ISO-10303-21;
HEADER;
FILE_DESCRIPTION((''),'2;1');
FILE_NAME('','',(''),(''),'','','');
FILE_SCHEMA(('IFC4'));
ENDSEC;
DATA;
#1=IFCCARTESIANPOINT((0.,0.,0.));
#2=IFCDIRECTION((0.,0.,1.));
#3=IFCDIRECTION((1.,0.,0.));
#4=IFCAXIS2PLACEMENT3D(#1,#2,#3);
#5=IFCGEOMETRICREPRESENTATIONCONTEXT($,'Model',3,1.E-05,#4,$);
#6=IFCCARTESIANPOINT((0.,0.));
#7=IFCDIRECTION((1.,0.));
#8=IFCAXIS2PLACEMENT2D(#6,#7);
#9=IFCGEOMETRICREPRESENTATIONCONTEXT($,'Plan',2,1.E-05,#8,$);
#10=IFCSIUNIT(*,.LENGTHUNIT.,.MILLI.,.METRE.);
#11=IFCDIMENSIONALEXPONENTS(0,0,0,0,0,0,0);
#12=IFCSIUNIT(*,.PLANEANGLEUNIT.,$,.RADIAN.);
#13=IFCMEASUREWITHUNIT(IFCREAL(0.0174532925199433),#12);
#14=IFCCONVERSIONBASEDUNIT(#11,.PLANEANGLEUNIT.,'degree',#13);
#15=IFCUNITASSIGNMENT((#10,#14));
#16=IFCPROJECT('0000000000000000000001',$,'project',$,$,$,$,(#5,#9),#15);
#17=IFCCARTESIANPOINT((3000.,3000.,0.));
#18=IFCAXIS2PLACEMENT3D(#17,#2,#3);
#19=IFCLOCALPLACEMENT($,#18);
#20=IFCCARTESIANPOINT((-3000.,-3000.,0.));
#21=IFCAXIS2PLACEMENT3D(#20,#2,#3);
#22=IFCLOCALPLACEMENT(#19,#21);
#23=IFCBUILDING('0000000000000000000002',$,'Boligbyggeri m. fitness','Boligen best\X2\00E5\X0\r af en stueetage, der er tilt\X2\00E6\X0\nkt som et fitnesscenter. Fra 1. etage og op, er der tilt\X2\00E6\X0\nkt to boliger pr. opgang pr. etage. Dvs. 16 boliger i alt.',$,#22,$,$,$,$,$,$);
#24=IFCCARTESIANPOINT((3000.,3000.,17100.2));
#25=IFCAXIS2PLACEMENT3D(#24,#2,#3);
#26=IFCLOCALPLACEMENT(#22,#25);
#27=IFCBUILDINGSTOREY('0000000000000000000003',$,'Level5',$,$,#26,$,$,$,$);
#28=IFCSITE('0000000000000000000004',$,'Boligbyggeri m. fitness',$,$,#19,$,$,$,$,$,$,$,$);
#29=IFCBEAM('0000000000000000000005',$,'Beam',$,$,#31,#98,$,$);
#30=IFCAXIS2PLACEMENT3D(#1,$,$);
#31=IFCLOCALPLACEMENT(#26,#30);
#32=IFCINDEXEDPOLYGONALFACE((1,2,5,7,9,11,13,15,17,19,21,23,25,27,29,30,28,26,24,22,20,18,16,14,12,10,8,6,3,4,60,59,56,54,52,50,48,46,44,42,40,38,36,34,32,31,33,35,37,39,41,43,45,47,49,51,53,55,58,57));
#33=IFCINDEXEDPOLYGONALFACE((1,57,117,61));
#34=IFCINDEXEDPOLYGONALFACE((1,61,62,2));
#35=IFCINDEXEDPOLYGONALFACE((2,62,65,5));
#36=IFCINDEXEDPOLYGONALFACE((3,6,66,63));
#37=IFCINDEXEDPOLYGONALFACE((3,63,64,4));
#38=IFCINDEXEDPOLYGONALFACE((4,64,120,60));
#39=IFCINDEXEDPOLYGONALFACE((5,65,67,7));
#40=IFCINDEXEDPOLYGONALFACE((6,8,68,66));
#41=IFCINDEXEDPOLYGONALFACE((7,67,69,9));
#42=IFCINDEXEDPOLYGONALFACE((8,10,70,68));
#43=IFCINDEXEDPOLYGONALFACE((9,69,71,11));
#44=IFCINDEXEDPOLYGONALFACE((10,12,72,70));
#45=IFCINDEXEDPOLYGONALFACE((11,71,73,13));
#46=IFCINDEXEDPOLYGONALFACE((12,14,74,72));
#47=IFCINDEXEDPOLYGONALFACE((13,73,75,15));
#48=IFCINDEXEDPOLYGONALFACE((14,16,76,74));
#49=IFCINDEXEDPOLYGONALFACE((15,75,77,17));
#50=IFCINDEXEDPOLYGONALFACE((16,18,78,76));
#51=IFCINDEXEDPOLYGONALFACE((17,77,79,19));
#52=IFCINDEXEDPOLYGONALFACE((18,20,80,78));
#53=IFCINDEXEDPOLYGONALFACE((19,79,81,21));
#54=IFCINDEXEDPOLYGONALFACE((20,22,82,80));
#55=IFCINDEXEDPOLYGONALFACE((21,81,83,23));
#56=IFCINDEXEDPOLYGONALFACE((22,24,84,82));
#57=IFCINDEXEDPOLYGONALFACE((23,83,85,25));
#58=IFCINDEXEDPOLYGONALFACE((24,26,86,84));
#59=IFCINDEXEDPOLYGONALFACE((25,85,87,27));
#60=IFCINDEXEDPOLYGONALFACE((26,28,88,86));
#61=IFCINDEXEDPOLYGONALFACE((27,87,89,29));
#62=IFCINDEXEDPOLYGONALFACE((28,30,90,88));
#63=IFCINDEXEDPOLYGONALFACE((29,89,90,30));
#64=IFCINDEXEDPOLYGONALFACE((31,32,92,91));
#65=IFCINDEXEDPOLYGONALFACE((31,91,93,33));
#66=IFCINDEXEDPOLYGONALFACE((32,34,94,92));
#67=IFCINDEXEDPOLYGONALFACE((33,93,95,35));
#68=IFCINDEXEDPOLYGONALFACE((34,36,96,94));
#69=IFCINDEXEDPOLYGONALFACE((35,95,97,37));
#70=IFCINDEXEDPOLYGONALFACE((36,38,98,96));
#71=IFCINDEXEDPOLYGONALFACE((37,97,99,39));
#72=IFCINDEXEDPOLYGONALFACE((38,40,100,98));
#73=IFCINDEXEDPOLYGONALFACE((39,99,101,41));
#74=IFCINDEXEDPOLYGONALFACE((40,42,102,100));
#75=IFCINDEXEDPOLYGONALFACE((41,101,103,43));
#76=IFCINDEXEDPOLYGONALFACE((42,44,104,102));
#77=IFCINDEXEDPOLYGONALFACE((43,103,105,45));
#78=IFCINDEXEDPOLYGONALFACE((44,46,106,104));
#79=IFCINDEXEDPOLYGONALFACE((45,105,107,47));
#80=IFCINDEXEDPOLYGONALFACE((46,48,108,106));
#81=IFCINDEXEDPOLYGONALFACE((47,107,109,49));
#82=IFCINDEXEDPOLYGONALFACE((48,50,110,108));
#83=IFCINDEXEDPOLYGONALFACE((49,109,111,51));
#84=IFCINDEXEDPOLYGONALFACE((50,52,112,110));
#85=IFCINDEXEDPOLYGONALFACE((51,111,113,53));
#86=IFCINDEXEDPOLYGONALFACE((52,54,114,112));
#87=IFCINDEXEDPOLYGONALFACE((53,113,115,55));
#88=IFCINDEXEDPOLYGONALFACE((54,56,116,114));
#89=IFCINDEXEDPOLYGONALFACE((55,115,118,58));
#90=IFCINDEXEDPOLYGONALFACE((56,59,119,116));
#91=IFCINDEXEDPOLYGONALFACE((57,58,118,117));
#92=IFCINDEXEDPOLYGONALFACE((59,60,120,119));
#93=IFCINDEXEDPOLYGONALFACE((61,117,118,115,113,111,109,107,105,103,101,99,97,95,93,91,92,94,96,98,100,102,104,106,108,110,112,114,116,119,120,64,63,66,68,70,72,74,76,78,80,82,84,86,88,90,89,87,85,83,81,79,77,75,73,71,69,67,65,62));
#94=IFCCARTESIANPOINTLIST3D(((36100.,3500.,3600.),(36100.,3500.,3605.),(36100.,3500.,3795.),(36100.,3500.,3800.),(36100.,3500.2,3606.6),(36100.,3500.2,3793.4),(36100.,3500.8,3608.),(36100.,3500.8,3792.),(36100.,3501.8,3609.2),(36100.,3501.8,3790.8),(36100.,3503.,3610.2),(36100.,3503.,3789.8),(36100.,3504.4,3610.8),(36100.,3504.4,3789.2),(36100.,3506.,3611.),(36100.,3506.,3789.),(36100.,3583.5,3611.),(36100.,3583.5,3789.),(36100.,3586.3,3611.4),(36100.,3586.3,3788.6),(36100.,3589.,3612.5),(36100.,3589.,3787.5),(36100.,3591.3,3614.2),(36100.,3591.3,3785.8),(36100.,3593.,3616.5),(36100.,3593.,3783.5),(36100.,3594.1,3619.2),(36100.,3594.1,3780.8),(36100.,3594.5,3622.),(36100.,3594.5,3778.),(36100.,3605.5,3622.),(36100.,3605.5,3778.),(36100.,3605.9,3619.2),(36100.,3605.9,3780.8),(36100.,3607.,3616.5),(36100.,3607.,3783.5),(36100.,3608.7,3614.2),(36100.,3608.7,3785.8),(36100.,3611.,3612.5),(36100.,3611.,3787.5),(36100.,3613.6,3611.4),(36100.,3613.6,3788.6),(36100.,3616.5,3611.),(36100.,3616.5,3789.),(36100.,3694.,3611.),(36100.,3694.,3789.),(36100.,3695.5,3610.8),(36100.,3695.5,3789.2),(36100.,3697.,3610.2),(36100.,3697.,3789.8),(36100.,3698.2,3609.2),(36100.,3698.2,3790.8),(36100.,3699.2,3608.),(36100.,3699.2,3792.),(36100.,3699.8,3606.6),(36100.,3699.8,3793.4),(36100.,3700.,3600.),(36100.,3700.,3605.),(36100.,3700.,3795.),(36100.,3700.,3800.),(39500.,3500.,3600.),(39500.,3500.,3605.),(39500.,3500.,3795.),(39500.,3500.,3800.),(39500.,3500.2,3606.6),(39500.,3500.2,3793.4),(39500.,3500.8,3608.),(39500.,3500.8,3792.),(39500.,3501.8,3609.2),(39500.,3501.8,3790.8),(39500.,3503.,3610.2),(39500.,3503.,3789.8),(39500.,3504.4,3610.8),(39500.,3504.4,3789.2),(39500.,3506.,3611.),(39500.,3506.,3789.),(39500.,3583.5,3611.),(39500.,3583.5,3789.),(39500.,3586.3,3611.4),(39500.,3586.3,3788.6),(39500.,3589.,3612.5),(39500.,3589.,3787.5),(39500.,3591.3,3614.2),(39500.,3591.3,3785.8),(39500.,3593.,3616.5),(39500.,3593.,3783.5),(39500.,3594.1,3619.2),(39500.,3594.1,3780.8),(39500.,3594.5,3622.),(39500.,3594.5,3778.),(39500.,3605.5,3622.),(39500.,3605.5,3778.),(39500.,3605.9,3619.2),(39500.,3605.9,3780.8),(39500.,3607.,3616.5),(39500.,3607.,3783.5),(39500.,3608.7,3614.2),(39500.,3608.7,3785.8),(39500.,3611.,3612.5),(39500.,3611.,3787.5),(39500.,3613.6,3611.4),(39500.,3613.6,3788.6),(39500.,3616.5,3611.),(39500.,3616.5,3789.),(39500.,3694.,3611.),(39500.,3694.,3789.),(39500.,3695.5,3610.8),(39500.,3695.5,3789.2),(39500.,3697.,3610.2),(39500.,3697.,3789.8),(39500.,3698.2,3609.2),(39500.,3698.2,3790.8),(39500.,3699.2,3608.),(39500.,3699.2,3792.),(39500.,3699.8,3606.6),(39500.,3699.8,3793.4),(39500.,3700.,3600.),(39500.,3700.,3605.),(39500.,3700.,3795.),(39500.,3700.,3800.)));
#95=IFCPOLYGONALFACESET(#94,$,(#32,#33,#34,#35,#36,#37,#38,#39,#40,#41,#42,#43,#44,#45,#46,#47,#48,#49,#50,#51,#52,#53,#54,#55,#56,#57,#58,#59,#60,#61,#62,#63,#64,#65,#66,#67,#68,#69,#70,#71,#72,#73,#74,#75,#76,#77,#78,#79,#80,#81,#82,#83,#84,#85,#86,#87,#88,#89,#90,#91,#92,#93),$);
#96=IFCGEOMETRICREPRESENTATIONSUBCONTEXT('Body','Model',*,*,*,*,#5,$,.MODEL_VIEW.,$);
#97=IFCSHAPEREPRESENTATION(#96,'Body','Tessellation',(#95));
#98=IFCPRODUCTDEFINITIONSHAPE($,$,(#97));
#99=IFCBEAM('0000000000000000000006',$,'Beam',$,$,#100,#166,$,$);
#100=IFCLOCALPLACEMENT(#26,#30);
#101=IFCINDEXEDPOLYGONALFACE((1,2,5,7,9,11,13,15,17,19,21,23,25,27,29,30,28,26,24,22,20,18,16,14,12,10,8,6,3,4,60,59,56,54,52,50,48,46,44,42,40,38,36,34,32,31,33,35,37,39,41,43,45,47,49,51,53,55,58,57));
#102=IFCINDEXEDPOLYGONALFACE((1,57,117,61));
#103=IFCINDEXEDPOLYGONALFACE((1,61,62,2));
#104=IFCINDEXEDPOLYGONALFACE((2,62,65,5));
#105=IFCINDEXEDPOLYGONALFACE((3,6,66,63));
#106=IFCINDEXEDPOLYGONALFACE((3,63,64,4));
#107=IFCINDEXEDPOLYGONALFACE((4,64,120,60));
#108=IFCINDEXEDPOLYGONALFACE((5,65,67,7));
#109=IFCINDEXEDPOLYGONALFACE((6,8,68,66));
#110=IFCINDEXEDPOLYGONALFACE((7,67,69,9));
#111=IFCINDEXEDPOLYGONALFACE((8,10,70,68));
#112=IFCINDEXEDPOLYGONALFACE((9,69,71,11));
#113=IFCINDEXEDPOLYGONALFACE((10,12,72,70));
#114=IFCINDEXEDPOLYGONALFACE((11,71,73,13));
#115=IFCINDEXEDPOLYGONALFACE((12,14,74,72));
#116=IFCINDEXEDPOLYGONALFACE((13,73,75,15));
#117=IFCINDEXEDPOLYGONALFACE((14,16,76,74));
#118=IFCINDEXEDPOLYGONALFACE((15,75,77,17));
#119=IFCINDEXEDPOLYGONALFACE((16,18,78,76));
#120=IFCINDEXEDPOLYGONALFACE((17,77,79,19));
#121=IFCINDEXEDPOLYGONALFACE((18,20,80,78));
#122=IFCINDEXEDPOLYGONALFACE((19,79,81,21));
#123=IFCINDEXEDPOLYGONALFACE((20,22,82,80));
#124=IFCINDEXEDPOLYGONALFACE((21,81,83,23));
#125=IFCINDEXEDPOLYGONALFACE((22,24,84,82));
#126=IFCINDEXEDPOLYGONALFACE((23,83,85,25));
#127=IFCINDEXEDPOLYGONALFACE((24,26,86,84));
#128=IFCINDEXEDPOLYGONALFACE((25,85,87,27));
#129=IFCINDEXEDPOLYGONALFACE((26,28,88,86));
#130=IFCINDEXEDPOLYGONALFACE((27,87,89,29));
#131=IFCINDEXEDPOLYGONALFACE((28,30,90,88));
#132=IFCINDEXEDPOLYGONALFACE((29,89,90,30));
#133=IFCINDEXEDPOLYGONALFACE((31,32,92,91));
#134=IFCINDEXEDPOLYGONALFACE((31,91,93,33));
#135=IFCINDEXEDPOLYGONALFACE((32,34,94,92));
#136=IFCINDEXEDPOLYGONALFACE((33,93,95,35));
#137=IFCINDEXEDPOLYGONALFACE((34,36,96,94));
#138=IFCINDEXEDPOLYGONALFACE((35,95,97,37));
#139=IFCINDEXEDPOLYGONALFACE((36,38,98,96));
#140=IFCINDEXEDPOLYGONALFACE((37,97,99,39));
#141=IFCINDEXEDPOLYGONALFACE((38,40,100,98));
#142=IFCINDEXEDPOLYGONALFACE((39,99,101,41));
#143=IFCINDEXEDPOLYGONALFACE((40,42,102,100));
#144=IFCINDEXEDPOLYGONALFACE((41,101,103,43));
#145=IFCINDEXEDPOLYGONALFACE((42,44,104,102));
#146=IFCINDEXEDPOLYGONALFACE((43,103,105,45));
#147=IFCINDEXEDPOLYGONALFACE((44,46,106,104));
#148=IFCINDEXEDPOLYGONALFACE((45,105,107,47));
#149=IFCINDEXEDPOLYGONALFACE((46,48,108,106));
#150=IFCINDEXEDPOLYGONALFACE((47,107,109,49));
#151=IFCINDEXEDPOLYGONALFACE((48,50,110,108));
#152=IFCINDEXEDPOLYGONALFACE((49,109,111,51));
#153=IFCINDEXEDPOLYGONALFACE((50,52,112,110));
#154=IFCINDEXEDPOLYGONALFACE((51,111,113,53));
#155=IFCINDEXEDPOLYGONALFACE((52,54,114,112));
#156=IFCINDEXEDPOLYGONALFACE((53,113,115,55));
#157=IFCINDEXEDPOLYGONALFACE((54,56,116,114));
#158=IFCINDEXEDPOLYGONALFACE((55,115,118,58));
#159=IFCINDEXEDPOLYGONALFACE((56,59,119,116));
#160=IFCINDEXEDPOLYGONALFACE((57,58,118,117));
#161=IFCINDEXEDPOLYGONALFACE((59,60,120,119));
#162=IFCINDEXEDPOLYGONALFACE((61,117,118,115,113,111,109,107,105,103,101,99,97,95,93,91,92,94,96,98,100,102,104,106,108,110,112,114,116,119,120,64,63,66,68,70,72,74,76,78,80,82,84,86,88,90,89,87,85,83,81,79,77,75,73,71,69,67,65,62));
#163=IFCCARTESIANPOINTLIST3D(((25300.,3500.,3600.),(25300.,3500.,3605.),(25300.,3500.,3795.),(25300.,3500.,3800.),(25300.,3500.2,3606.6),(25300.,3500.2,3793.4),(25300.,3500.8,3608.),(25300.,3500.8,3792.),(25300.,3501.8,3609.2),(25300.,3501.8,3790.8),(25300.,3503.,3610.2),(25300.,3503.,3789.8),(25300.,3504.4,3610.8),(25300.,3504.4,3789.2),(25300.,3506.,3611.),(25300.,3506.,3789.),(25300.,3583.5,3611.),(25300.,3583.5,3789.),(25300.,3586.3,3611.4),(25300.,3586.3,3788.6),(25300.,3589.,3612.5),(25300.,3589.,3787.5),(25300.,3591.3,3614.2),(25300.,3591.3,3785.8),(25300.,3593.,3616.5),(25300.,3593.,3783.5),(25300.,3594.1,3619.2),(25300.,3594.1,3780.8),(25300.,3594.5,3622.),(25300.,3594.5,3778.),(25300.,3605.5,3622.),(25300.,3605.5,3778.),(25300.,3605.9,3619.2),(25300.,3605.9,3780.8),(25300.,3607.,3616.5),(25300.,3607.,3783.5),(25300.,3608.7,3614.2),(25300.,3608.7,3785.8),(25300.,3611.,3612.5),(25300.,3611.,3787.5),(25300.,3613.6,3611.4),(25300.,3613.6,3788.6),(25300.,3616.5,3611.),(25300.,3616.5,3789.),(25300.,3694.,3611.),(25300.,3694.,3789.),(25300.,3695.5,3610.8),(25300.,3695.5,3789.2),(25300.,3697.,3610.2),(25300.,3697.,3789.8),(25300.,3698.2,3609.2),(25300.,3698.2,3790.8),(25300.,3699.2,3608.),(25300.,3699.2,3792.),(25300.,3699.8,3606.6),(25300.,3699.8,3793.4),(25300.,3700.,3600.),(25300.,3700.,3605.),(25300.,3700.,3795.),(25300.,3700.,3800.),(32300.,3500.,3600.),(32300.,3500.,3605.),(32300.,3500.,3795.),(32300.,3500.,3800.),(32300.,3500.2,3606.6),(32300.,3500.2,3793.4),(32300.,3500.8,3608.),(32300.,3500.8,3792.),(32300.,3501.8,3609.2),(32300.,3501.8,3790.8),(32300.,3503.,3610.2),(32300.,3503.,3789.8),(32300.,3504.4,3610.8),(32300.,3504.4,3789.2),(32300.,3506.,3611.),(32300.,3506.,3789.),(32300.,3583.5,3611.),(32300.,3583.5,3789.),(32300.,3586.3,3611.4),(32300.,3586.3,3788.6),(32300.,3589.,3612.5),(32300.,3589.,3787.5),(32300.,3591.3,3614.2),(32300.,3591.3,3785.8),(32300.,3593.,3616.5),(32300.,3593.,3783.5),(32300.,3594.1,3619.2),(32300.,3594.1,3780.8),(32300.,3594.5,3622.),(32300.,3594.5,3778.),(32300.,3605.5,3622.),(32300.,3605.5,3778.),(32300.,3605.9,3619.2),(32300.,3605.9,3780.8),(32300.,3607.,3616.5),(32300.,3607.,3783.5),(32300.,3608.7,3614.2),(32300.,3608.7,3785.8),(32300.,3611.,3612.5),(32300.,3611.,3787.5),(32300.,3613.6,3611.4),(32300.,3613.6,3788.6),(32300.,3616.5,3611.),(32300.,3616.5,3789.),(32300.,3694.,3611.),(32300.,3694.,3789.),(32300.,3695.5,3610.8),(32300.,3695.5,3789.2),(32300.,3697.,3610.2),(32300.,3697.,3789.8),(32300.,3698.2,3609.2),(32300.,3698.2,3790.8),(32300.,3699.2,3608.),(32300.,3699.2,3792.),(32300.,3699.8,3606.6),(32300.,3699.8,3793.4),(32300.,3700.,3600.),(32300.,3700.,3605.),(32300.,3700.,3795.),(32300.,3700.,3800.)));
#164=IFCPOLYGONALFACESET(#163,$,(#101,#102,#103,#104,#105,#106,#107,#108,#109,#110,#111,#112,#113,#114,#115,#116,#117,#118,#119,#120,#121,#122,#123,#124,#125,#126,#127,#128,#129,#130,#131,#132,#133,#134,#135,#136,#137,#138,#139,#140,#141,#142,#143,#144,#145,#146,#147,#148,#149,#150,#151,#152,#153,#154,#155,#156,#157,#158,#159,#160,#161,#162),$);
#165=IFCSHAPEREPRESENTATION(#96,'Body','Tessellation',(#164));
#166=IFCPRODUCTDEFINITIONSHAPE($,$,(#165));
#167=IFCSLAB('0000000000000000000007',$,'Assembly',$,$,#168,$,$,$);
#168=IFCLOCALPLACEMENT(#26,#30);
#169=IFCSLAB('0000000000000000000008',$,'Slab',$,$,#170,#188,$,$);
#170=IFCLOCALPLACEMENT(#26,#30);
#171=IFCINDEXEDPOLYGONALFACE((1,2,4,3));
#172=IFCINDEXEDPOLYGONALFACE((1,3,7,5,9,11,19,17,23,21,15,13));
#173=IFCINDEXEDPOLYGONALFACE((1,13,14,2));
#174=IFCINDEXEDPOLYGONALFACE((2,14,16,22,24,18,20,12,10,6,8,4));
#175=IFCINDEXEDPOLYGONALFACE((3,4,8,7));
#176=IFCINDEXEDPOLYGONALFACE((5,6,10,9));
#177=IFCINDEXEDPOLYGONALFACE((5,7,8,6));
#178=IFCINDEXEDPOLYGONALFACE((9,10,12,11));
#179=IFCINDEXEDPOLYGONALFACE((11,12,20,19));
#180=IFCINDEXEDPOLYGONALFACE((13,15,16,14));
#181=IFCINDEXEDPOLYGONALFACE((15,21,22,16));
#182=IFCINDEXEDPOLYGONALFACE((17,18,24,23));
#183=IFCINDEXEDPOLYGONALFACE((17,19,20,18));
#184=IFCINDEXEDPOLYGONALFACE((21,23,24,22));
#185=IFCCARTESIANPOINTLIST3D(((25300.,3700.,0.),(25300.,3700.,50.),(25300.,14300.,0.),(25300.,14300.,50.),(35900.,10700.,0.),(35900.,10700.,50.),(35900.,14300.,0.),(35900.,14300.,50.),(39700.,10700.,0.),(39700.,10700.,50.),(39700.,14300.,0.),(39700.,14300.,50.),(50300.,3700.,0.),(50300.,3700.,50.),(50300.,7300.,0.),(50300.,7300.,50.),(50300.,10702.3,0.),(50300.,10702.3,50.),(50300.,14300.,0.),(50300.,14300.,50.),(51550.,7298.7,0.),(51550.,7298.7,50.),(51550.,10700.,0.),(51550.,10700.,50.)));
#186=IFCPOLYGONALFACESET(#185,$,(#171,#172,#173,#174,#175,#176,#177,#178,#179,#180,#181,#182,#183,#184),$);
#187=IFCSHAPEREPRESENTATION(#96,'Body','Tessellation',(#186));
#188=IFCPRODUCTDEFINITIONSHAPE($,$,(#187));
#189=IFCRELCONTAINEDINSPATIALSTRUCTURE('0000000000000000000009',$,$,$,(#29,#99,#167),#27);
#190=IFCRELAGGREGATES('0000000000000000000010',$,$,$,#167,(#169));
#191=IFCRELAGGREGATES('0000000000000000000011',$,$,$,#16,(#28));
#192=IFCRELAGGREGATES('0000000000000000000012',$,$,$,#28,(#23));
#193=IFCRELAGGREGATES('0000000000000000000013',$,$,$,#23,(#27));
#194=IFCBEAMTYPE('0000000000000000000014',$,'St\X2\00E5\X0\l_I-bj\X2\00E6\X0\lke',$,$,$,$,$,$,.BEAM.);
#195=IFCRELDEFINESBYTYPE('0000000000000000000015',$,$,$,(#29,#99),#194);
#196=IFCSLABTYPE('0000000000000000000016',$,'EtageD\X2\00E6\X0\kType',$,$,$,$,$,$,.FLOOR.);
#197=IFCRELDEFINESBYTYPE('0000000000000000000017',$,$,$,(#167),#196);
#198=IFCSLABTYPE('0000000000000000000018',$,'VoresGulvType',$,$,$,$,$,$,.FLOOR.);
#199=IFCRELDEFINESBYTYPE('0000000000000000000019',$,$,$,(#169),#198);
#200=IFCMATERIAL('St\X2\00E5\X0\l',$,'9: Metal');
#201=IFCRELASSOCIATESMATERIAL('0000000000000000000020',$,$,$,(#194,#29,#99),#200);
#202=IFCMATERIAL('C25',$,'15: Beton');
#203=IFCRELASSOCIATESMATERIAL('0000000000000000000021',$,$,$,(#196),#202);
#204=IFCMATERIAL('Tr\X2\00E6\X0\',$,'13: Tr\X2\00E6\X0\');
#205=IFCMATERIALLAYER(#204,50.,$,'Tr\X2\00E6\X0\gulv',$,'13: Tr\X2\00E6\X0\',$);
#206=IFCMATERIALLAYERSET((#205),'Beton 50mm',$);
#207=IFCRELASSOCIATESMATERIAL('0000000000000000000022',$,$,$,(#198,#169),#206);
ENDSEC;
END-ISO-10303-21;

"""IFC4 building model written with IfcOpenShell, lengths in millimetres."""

from ifc_helpers import new_model, entity, si_unit, converted_unit, frame, origin_with_axes, origin_2d_with_axis, place, context, subcontext, project, spatial, line, indexed_curve, i_section, outline, extrude, material, layer, layer_set, layer_usage, material_profile, profile_set, profile_usage, type_object, element, aggregate, save


model = new_model("IFC4")

# Units and contexts
model_context = context("Model", 3, precision=1e-05, world=origin_with_axes())
plan_context = context("Plan", 2, precision=1e-05, world=origin_2d_with_axis())
body_context = subcontext(model_context, "Body", "Model", "MODEL_VIEW")
ifc_project = project(units=[si_unit("LENGTHUNIT", "METRE", prefix="MILLI"), converted_unit("PLANEANGLEUNIT", "degree", entity("IfcReal", 0.0174532925199433), si_unit("PLANEANGLEUNIT", "RADIAN"), dimensions=[0, 0, 0, 0, 0, 0, 0])], contexts=[model_context, plan_context])

# Site, building, storey
site_placement = place(None, frame((3000.0, 3000.0, 0.0), z_axis=(0.0, 0.0, 1.0), x_axis=(1.0, 0.0, 0.0)))
site = spatial("IfcSite", under=ifc_project, at=site_placement, Name="Boligbyggeri m. fitness")
building_placement = place(site_placement, frame((-3000.0, -3000.0, 0.0), z_axis=(0.0, 0.0, 1.0), x_axis=(1.0, 0.0, 0.0)))
building = spatial("IfcBuilding", under=site, at=building_placement, Name="Boligbyggeri m. fitness", Description="Boligen består af en stueetage, der er tiltænkt som et fitnesscenter. Fra 1. etage og op, er der tiltænkt to boliger pr. opgang pr. etage. Dvs. 16 boliger i alt.")
storey_placement = place(building_placement, frame((3000.0, 3000.0, 17100.2), z_axis=(0.0, 0.0, 1.0), x_axis=(1.0, 0.0, 0.0)))
storey = spatial("IfcBuildingStorey", under=building, at=storey_placement, Name="Level5")

# Shared definitions
ifc_material_1 = material(Name="C25", Category="15: Beton")

# Beams
ifc_material_2 = material(Name="Stål", Category="9: Metal")
ifc_material_profile_1 = material_profile(ifc_material_2, i_section(OverallWidth=200.0, OverallDepth=200.0, WebThickness=11.0, FlangeThickness=11.0, FilletRadius=11.0, FlangeEdgeRadius=6.0), Name="Stål", Category="9: Metal")
ifc_profile_set_1 = profile_set([ifc_material_profile_1], Name="NY_I-Profil")
beam_type = type_object("IfcBeamType", Name="Stål_I-bjælke", PredefinedType="BEAM", material=ifc_profile_set_1)
ifc_profile_usage_1 = profile_usage(ifc_profile_set_1, cardinal=7)
beam_1_placement = place(storey_placement, frame((36100.0, 3700.0, 3800.0), z_axis=(1.0, 0.0, 0.0), x_axis=(0.0, 1.0, 0.0)))
element("IfcBeam", 1, at=beam_1_placement, inside=storey, type_object=beam_type, material=ifc_profile_usage_1, Name="Beam", context=body_context, shape_type="SweptSolid", body=[
    extrude(i_section(OverallWidth=200.0, OverallDepth=200.0, WebThickness=11.0, FlangeThickness=11.0, FilletRadius=11.0, FlangeEdgeRadius=6.0), frame((-100.0, -100.0, 0.0), z_axis=(0.0, 0.0, 1.0), x_axis=(1.0, 0.0, 0.0)), (0.0, 0.0, 1.0), 3400.0),
])
ifc_profile_usage_2 = profile_usage(ifc_profile_set_1, cardinal=7)
beam_2_placement = place(storey_placement, frame((25300.0, 3700.0, 3800.0), z_axis=(1.0, 0.0, 0.0), x_axis=(0.0, 1.0, 0.0)))
element("IfcBeam", 2, at=beam_2_placement, inside=storey, type_object=beam_type, material=ifc_profile_usage_2, Name="Beam", context=body_context, shape_type="SweptSolid", body=[
    extrude(i_section(OverallWidth=200.0, OverallDepth=200.0, WebThickness=11.0, FlangeThickness=11.0, FilletRadius=11.0, FlangeEdgeRadius=6.0), frame((-100.0, -100.0, 0.0), z_axis=(0.0, 0.0, 1.0), x_axis=(1.0, 0.0, 0.0)), (0.0, 0.0, 1.0), 7000.0),
])

# Slabs
slab_type_1 = type_object("IfcSlabType", Name="EtageDækType", PredefinedType="FLOOR", material=ifc_material_1)
slab_1_placement = place(storey_placement, frame((25300.0, 3700.0, -17099.9), z_axis=(0.0, 0.0, 1.0), x_axis=(1.0, 0.0, 0.0)))
slab_1 = element("IfcSlab", 3, at=slab_1_placement, inside=storey, type_object=slab_type_1, Name="Assembly")
ifc_material_3 = material(Name="Træ", Category="13: Træ")
ifc_layer_1 = layer(ifc_material_3, 50.0, Name="Trægulv", Category="13: Træ")
ifc_layer_set_1 = layer_set([ifc_layer_1], Name="Beton 50mm")
ifc_layer_usage_1 = layer_usage(ifc_layer_set_1, "AXIS3", "POSITIVE", 0.0)
slab_type_2 = type_object("IfcSlabType", Name="VoresGulvType", PredefinedType="FLOOR", material=ifc_layer_set_1)
slab_2_placement = place(slab_1_placement, frame((0.0, 0.0, 17099.9), z_axis=(0.0, 0.0, 1.0), x_axis=(1.0, 0.0, 0.0)))
slab_2 = element("IfcSlab", 4, at=slab_2_placement, type_object=slab_type_2, material=ifc_layer_usage_1, Name="Slab", context=body_context, shape_type="SweptSolid", body=[
    extrude(outline(indexed_curve([(10600.0, 7000.0), (10600.0, 10600.0), (0.0, 10600.0), (0.0, 0.0), (25000.0, 0.0), (25000.0, 10600.0), (14400.0, 10600.0), (14400.0, 7000.0), (25000.0, 3600.0), (25000.0, 7002.3), (26250.0, 7000.0), (26250.0, 3598.7)], segments=[line(11, 10), line(10, 6), line(6, 7), line(7, 8), line(8, 1), line(1, 2), line(2, 3), line(3, 4), line(4, 5), line(5, 9), line(9, 12), line(12, 11)], self_intersect=False)), None, (0.0, 0.0, 1.0), 50.0),
])
aggregate(slab_1, [slab_2])

save(model, "model.ifc")
